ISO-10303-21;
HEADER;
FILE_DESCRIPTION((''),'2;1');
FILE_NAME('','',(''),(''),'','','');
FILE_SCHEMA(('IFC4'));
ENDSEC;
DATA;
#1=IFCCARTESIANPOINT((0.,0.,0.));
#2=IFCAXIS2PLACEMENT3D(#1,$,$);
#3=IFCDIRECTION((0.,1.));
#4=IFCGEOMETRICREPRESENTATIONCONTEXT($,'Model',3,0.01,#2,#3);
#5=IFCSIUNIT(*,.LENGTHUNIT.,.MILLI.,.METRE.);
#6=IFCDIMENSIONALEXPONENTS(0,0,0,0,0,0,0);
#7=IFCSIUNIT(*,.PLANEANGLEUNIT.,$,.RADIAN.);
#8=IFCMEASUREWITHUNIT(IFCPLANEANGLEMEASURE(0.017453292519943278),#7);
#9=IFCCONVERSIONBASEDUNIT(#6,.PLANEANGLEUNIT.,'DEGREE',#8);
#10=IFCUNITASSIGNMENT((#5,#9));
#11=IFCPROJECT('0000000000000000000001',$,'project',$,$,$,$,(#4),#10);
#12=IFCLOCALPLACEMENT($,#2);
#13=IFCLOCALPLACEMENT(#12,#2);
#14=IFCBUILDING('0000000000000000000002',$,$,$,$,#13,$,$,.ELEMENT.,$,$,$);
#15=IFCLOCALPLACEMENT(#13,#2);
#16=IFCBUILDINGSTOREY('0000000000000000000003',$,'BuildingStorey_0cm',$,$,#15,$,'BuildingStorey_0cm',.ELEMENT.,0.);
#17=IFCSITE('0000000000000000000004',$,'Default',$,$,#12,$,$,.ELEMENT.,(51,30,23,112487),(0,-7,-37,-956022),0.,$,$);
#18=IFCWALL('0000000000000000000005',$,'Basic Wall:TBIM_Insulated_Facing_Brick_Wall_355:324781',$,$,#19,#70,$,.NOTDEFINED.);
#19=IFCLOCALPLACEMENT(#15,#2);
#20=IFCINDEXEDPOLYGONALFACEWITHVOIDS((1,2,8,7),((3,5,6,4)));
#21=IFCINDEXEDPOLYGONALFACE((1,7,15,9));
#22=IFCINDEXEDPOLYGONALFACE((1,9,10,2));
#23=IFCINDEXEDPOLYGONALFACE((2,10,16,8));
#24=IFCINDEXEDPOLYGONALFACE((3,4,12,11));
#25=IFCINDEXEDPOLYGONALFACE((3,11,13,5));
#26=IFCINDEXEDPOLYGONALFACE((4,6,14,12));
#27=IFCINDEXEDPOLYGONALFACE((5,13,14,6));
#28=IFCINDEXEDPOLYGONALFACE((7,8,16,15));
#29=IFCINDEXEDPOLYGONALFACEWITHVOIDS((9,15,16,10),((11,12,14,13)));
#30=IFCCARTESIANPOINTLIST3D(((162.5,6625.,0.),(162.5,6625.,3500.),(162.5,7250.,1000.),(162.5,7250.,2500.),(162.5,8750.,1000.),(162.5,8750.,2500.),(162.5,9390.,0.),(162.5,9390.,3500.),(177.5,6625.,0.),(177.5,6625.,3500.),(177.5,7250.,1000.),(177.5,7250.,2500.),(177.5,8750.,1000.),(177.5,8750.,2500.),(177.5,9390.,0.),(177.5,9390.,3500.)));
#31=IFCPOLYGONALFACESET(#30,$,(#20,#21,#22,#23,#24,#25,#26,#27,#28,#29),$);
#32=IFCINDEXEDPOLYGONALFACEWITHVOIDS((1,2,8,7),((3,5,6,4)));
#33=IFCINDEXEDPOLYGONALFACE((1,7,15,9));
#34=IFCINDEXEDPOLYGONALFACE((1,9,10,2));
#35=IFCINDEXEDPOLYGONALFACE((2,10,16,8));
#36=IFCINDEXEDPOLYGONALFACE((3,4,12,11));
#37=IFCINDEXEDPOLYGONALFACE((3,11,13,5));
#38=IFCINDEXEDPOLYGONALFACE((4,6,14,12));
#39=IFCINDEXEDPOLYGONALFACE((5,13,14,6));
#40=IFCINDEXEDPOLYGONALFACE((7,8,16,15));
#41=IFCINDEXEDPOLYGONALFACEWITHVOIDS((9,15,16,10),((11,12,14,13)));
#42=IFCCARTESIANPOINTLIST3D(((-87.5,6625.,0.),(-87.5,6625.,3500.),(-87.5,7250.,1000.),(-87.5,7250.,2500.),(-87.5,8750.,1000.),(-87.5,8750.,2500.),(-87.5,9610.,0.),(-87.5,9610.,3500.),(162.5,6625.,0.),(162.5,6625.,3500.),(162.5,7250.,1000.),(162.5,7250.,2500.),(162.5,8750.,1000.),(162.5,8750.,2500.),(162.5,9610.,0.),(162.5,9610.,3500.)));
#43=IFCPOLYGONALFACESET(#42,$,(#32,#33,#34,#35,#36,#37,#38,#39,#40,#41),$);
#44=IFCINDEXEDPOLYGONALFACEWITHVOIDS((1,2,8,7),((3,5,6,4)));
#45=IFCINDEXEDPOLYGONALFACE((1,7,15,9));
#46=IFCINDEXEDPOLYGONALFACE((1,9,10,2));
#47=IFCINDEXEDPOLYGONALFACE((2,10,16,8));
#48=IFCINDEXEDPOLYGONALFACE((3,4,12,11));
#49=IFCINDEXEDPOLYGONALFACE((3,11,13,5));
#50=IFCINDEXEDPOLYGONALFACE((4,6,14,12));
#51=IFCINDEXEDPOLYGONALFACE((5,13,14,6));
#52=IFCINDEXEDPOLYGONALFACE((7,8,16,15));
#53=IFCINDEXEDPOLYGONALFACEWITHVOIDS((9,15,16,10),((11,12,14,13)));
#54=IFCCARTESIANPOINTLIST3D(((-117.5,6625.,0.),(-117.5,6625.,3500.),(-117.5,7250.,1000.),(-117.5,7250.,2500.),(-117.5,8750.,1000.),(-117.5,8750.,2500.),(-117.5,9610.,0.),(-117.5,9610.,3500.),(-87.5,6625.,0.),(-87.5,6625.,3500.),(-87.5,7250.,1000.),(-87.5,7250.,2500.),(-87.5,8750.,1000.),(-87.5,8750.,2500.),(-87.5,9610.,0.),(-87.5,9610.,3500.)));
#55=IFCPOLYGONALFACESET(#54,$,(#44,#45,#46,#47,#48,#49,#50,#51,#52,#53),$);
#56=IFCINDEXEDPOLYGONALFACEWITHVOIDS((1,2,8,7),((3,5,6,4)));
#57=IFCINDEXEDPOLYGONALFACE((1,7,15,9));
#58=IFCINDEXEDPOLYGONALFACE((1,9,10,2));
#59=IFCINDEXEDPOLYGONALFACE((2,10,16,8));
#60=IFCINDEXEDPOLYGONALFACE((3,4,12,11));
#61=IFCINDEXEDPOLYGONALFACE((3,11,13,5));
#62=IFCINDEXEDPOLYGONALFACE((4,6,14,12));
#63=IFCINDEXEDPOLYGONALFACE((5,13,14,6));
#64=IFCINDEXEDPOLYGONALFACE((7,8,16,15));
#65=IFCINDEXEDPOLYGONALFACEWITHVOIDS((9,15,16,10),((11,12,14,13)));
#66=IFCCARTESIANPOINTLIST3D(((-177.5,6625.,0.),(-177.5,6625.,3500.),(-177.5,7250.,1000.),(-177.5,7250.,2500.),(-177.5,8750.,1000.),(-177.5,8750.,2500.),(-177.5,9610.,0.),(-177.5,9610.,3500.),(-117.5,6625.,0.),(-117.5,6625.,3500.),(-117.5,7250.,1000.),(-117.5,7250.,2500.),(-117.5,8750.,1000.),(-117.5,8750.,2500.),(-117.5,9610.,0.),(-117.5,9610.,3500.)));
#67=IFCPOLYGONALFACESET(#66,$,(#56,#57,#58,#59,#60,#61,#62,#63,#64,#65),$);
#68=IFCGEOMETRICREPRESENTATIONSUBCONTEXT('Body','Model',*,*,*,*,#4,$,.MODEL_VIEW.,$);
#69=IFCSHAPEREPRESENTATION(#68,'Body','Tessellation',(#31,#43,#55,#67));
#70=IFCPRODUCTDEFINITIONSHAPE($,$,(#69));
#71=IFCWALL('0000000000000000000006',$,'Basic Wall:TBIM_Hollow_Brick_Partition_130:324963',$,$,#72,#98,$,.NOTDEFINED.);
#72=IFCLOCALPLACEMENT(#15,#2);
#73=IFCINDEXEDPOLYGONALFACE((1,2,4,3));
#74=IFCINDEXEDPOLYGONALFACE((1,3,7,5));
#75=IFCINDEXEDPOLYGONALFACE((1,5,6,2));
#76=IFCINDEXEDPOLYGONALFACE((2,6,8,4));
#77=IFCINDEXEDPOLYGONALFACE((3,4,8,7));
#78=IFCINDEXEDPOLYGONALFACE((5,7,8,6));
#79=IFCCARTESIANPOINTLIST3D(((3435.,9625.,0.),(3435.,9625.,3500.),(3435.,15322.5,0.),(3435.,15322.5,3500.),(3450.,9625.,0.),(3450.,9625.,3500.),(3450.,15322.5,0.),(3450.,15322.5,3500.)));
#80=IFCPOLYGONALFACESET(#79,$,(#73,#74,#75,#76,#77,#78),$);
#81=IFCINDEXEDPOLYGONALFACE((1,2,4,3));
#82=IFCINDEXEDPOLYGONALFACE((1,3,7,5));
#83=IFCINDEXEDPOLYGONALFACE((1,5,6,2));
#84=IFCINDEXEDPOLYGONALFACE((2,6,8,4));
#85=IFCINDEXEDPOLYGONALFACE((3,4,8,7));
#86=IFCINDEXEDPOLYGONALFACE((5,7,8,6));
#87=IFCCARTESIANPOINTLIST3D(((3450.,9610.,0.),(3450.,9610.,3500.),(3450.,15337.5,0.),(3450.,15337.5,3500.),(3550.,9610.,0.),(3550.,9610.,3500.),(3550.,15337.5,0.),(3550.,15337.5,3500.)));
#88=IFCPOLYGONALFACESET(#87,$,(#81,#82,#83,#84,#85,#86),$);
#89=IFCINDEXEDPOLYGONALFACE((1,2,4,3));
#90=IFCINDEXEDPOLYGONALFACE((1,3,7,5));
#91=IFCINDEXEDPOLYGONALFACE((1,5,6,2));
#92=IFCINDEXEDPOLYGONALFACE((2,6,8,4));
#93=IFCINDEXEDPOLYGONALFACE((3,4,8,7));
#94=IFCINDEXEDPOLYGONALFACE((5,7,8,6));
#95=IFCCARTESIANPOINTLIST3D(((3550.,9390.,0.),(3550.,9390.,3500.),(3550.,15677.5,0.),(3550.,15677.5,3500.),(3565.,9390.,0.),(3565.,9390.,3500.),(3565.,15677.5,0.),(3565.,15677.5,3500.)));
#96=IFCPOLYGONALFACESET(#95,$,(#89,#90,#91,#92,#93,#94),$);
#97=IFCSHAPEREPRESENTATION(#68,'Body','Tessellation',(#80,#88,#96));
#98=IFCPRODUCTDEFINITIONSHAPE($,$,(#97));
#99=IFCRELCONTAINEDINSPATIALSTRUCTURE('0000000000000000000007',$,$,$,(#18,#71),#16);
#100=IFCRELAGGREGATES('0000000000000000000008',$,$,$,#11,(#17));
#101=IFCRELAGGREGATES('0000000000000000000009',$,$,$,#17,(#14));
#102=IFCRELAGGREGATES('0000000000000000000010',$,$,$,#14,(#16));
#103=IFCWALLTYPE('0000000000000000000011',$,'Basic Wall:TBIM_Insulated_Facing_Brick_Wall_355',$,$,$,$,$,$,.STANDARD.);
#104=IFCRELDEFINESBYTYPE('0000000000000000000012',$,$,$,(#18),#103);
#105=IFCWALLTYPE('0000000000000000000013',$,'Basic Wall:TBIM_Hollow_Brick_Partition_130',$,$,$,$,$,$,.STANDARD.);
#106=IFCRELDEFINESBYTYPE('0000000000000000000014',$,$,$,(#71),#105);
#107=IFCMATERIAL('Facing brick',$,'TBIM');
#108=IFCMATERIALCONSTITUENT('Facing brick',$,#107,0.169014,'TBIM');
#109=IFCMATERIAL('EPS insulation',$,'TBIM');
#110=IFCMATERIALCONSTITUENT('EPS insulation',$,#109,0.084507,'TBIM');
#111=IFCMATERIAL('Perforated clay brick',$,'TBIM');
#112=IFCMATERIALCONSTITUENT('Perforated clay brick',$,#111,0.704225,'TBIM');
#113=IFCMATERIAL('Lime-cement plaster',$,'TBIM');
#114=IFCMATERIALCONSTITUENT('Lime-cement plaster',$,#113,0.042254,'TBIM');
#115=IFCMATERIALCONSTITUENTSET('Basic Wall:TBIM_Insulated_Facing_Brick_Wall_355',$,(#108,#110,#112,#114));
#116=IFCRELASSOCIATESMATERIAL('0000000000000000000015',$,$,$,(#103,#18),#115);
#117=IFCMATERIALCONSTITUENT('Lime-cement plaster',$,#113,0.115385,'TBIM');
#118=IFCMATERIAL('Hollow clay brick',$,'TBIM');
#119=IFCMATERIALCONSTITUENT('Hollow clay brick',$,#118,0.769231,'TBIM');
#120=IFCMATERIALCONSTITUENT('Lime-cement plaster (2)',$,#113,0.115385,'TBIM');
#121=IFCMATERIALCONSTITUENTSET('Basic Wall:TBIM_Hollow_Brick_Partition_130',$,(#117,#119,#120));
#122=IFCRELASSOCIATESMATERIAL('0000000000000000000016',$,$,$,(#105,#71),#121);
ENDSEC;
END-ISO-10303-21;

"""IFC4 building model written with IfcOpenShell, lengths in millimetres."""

from ifc_helpers import new_model, entity, si_unit, converted_unit, direction, frame, origin, place, context, subcontext, project, spatial, indexed_curve, outline, extrude, material, constituent, constituent_set, type_object, element, save


model = new_model("IFC4")

# Units and contexts
model_context = context("Model", 3, precision=0.01, world=origin(), true_north=direction((0.0, 1.0)))
body_context = subcontext(model_context, "Body", "Model", "MODEL_VIEW")
ifc_project = project(units=[si_unit("LENGTHUNIT", "METRE", prefix="MILLI"), converted_unit("PLANEANGLEUNIT", "DEGREE", entity("IfcPlaneAngleMeasure", 0.017453292519943278), si_unit("PLANEANGLEUNIT", "RADIAN"), dimensions=[0, 0, 0, 0, 0, 0, 0])], contexts=[model_context])

# Site, building, storey
site_placement = place(None, origin())
site = spatial("IfcSite", under=ifc_project, at=site_placement, Name="Default", CompositionType="ELEMENT", RefLatitude=(51, 30, 23, 112487), RefLongitude=(0, -7, -37, -956022), RefElevation=0.0)
building_placement = place(site_placement, origin())
building = spatial("IfcBuilding", under=site, at=building_placement, CompositionType="ELEMENT")
storey_placement = place(building_placement, origin())
storey = spatial("IfcBuildingStorey", under=building, at=storey_placement, Name="BuildingStorey_0cm", LongName="BuildingStorey_0cm", CompositionType="ELEMENT", Elevation=0.0)

# Shared definitions
ifc_material_1 = material(Name="Facing brick", Category="TBIM")
ifc_constituent_1 = constituent(ifc_material_1, Name="Facing brick", Category="TBIM", fraction=0.169014)
ifc_material_2 = material(Name="EPS insulation", Category="TBIM")
ifc_constituent_2 = constituent(ifc_material_2, Name="EPS insulation", Category="TBIM", fraction=0.084507)
ifc_material_3 = material(Name="Perforated clay brick", Category="TBIM")
ifc_constituent_3 = constituent(ifc_material_3, Name="Perforated clay brick", Category="TBIM", fraction=0.704225)
ifc_material_4 = material(Name="Lime-cement plaster", Category="TBIM")
ifc_constituent_4 = constituent(ifc_material_4, Name="Lime-cement plaster", Category="TBIM", fraction=0.042254)
ifc_constituent_set_1 = constituent_set(constituents=[ifc_constituent_1, ifc_constituent_2, ifc_constituent_3, ifc_constituent_4], Name="Basic Wall:TBIM_Insulated_Facing_Brick_Wall_355")
wall_type_1 = type_object("IfcWallType", Name="Basic Wall:TBIM_Insulated_Facing_Brick_Wall_355", PredefinedType="STANDARD", material=ifc_constituent_set_1)

# Wall, opening
wall_1_placement = place(storey_placement, frame((0.0, 9625.0, 0.0), z_axis=(0.0, 0.0, 1.0), x_axis=(0.0, -1.0, 0.0)))
wall_1 = element("IfcWall", 1, at=wall_1_placement, inside=storey, type_object=wall_type_1, material=ifc_constituent_set_1, Name="Basic Wall:TBIM_Insulated_Facing_Brick_Wall_355:324781", PredefinedType="NOTDEFINED", context=body_context, shape_type="SweptSolid", body=[
    extrude(outline(indexed_curve([(-1750.0, -1382.5), (1750.0, -1382.5), (1750.0, 1382.5), (-1750.0, 1382.5), (-1750.0, -1382.5)], self_intersect=False), holes=[indexed_curve([(-750.0, -742.5), (-750.0, 757.5), (750.0, 757.5), (750.0, -742.5), (-750.0, -742.5)], self_intersect=False)]), frame((1617.5, 162.5, 1750.0), z_axis=(0.0, 1.0, 0.0), x_axis=(0.0, 0.0, 1.0)), (0.0, 0.0, 1.0), 15.0),
    extrude(outline(indexed_curve([(-1750.0, -1492.5), (1750.0, -1492.5), (1750.0, 1492.5), (-1750.0, 1492.5), (-1750.0, -1492.5)], self_intersect=False), holes=[indexed_curve([(-750.0, -632.5), (-750.0, 867.5), (750.0, 867.5), (750.0, -632.5), (-750.0, -632.5)], self_intersect=False)]), frame((1507.5, -87.5, 1750.0), z_axis=(0.0, 1.0, 0.0), x_axis=(0.0, 0.0, 1.0)), (0.0, 0.0, 1.0), 250.0),
    extrude(outline(indexed_curve([(-1750.0, -1492.5), (1750.0, -1492.5), (1750.0, 1492.5), (-1750.0, 1492.5), (-1750.0, -1492.5)], self_intersect=False), holes=[indexed_curve([(-750.0, -632.5), (-750.0, 867.5), (750.0, 867.5), (750.0, -632.5), (-750.0, -632.5)], self_intersect=False)]), frame((1507.5, -117.5, 1750.0), z_axis=(0.0, 1.0, 0.0), x_axis=(0.0, 0.0, 1.0)), (0.0, 0.0, 1.0), 30.0),
    extrude(outline(indexed_curve([(-1750.0, -1492.5), (1750.0, -1492.5), (1750.0, 1492.5), (-1750.0, 1492.5), (-1750.0, -1492.5)], self_intersect=False), holes=[indexed_curve([(750.0, -632.5), (-750.0, -632.5), (-750.0, 867.5), (750.0, 867.5), (750.0, -632.5)], self_intersect=False)]), frame((1507.5, -177.5, 1750.0), z_axis=(0.0, 1.0, 0.0), x_axis=(0.0, 0.0, 1.0)), (0.0, 0.0, 1.0), 60.0),
])
opening_1_placement = place(wall_1_placement, frame((875.0, -177.5, 1000.0)))
element("IfcOpeningElement", 2, at=opening_1_placement, cuts=wall_1, PredefinedType="OPENING", context=body_context, shape_type="SweptSolid", body=[
    extrude(outline(indexed_curve([(1500.0, 0.0), (1500.0, 1500.0), (0.0, 1500.0), (0.0, 0.0), (1500.0, 0.0)], self_intersect=False)), frame((0.0, 0.0, 0.0), z_axis=(0.0, 1.0, 0.0), x_axis=(0.0, 0.0, 1.0)), (0.0, 0.0, 1.0), 355.0),
])

# Wall
ifc_constituent_5 = constituent(ifc_material_4, Name="Lime-cement plaster", Category="TBIM", fraction=0.115385)
ifc_material_5 = material(Name="Hollow clay brick", Category="TBIM")
ifc_constituent_6 = constituent(ifc_material_5, Name="Hollow clay brick", Category="TBIM", fraction=0.769231)
ifc_constituent_7 = constituent(ifc_material_4, Name="Lime-cement plaster (2)", Category="TBIM", fraction=0.115385)
ifc_constituent_set_2 = constituent_set(constituents=[ifc_constituent_5, ifc_constituent_6, ifc_constituent_7], Name="Basic Wall:TBIM_Hollow_Brick_Partition_130")
wall_type_2 = type_object("IfcWallType", Name="Basic Wall:TBIM_Hollow_Brick_Partition_130", PredefinedType="STANDARD", material=ifc_constituent_set_2)
wall_2_placement = place(storey_placement, frame((3500.0, 9625.0, 0.0), z_axis=(0.0, 0.0, 1.0), x_axis=(0.0, 1.0, 0.0)))
element("IfcWall", 3, at=wall_2_placement, inside=storey, type_object=wall_type_2, material=ifc_constituent_set_2, Name="Basic Wall:TBIM_Hollow_Brick_Partition_130:324963", PredefinedType="NOTDEFINED", context=body_context, shape_type="SweptSolid", body=[
    extrude(outline(indexed_curve([(-7.5, -2848.8), (7.5, -2848.8), (7.5, 2848.7), (-7.5, 2848.7), (-7.5, -2848.8)], self_intersect=False)), frame((2848.8, 57.5, 0.0), z_axis=(0.0, 0.0, 1.0), x_axis=(0.0, -1.0, 0.0)), (0.0, 0.0, 1.0), 3500.0),
    extrude(outline(indexed_curve([(-2863.7, -50.0), (2863.7, -50.0), (2863.7, 50.0), (-2863.7, 50.0), (-2863.7, -50.0)], self_intersect=False)), frame((2848.8, 0.0, 0.0)), (0.0, 0.0, 1.0), 3500.0),
    extrude(outline(indexed_curve([(-7.5, -3143.8), (7.5, -3143.8), (7.5, 3143.7), (-7.5, 3143.7), (-7.5, -3143.8)], self_intersect=False)), frame((2908.7, -57.5, 0.0), z_axis=(0.0, 0.0, 1.0), x_axis=(0.0, 1.0, 0.0)), (0.0, 0.0, 1.0), 3500.0),
])

save(model, "model.ifc")
